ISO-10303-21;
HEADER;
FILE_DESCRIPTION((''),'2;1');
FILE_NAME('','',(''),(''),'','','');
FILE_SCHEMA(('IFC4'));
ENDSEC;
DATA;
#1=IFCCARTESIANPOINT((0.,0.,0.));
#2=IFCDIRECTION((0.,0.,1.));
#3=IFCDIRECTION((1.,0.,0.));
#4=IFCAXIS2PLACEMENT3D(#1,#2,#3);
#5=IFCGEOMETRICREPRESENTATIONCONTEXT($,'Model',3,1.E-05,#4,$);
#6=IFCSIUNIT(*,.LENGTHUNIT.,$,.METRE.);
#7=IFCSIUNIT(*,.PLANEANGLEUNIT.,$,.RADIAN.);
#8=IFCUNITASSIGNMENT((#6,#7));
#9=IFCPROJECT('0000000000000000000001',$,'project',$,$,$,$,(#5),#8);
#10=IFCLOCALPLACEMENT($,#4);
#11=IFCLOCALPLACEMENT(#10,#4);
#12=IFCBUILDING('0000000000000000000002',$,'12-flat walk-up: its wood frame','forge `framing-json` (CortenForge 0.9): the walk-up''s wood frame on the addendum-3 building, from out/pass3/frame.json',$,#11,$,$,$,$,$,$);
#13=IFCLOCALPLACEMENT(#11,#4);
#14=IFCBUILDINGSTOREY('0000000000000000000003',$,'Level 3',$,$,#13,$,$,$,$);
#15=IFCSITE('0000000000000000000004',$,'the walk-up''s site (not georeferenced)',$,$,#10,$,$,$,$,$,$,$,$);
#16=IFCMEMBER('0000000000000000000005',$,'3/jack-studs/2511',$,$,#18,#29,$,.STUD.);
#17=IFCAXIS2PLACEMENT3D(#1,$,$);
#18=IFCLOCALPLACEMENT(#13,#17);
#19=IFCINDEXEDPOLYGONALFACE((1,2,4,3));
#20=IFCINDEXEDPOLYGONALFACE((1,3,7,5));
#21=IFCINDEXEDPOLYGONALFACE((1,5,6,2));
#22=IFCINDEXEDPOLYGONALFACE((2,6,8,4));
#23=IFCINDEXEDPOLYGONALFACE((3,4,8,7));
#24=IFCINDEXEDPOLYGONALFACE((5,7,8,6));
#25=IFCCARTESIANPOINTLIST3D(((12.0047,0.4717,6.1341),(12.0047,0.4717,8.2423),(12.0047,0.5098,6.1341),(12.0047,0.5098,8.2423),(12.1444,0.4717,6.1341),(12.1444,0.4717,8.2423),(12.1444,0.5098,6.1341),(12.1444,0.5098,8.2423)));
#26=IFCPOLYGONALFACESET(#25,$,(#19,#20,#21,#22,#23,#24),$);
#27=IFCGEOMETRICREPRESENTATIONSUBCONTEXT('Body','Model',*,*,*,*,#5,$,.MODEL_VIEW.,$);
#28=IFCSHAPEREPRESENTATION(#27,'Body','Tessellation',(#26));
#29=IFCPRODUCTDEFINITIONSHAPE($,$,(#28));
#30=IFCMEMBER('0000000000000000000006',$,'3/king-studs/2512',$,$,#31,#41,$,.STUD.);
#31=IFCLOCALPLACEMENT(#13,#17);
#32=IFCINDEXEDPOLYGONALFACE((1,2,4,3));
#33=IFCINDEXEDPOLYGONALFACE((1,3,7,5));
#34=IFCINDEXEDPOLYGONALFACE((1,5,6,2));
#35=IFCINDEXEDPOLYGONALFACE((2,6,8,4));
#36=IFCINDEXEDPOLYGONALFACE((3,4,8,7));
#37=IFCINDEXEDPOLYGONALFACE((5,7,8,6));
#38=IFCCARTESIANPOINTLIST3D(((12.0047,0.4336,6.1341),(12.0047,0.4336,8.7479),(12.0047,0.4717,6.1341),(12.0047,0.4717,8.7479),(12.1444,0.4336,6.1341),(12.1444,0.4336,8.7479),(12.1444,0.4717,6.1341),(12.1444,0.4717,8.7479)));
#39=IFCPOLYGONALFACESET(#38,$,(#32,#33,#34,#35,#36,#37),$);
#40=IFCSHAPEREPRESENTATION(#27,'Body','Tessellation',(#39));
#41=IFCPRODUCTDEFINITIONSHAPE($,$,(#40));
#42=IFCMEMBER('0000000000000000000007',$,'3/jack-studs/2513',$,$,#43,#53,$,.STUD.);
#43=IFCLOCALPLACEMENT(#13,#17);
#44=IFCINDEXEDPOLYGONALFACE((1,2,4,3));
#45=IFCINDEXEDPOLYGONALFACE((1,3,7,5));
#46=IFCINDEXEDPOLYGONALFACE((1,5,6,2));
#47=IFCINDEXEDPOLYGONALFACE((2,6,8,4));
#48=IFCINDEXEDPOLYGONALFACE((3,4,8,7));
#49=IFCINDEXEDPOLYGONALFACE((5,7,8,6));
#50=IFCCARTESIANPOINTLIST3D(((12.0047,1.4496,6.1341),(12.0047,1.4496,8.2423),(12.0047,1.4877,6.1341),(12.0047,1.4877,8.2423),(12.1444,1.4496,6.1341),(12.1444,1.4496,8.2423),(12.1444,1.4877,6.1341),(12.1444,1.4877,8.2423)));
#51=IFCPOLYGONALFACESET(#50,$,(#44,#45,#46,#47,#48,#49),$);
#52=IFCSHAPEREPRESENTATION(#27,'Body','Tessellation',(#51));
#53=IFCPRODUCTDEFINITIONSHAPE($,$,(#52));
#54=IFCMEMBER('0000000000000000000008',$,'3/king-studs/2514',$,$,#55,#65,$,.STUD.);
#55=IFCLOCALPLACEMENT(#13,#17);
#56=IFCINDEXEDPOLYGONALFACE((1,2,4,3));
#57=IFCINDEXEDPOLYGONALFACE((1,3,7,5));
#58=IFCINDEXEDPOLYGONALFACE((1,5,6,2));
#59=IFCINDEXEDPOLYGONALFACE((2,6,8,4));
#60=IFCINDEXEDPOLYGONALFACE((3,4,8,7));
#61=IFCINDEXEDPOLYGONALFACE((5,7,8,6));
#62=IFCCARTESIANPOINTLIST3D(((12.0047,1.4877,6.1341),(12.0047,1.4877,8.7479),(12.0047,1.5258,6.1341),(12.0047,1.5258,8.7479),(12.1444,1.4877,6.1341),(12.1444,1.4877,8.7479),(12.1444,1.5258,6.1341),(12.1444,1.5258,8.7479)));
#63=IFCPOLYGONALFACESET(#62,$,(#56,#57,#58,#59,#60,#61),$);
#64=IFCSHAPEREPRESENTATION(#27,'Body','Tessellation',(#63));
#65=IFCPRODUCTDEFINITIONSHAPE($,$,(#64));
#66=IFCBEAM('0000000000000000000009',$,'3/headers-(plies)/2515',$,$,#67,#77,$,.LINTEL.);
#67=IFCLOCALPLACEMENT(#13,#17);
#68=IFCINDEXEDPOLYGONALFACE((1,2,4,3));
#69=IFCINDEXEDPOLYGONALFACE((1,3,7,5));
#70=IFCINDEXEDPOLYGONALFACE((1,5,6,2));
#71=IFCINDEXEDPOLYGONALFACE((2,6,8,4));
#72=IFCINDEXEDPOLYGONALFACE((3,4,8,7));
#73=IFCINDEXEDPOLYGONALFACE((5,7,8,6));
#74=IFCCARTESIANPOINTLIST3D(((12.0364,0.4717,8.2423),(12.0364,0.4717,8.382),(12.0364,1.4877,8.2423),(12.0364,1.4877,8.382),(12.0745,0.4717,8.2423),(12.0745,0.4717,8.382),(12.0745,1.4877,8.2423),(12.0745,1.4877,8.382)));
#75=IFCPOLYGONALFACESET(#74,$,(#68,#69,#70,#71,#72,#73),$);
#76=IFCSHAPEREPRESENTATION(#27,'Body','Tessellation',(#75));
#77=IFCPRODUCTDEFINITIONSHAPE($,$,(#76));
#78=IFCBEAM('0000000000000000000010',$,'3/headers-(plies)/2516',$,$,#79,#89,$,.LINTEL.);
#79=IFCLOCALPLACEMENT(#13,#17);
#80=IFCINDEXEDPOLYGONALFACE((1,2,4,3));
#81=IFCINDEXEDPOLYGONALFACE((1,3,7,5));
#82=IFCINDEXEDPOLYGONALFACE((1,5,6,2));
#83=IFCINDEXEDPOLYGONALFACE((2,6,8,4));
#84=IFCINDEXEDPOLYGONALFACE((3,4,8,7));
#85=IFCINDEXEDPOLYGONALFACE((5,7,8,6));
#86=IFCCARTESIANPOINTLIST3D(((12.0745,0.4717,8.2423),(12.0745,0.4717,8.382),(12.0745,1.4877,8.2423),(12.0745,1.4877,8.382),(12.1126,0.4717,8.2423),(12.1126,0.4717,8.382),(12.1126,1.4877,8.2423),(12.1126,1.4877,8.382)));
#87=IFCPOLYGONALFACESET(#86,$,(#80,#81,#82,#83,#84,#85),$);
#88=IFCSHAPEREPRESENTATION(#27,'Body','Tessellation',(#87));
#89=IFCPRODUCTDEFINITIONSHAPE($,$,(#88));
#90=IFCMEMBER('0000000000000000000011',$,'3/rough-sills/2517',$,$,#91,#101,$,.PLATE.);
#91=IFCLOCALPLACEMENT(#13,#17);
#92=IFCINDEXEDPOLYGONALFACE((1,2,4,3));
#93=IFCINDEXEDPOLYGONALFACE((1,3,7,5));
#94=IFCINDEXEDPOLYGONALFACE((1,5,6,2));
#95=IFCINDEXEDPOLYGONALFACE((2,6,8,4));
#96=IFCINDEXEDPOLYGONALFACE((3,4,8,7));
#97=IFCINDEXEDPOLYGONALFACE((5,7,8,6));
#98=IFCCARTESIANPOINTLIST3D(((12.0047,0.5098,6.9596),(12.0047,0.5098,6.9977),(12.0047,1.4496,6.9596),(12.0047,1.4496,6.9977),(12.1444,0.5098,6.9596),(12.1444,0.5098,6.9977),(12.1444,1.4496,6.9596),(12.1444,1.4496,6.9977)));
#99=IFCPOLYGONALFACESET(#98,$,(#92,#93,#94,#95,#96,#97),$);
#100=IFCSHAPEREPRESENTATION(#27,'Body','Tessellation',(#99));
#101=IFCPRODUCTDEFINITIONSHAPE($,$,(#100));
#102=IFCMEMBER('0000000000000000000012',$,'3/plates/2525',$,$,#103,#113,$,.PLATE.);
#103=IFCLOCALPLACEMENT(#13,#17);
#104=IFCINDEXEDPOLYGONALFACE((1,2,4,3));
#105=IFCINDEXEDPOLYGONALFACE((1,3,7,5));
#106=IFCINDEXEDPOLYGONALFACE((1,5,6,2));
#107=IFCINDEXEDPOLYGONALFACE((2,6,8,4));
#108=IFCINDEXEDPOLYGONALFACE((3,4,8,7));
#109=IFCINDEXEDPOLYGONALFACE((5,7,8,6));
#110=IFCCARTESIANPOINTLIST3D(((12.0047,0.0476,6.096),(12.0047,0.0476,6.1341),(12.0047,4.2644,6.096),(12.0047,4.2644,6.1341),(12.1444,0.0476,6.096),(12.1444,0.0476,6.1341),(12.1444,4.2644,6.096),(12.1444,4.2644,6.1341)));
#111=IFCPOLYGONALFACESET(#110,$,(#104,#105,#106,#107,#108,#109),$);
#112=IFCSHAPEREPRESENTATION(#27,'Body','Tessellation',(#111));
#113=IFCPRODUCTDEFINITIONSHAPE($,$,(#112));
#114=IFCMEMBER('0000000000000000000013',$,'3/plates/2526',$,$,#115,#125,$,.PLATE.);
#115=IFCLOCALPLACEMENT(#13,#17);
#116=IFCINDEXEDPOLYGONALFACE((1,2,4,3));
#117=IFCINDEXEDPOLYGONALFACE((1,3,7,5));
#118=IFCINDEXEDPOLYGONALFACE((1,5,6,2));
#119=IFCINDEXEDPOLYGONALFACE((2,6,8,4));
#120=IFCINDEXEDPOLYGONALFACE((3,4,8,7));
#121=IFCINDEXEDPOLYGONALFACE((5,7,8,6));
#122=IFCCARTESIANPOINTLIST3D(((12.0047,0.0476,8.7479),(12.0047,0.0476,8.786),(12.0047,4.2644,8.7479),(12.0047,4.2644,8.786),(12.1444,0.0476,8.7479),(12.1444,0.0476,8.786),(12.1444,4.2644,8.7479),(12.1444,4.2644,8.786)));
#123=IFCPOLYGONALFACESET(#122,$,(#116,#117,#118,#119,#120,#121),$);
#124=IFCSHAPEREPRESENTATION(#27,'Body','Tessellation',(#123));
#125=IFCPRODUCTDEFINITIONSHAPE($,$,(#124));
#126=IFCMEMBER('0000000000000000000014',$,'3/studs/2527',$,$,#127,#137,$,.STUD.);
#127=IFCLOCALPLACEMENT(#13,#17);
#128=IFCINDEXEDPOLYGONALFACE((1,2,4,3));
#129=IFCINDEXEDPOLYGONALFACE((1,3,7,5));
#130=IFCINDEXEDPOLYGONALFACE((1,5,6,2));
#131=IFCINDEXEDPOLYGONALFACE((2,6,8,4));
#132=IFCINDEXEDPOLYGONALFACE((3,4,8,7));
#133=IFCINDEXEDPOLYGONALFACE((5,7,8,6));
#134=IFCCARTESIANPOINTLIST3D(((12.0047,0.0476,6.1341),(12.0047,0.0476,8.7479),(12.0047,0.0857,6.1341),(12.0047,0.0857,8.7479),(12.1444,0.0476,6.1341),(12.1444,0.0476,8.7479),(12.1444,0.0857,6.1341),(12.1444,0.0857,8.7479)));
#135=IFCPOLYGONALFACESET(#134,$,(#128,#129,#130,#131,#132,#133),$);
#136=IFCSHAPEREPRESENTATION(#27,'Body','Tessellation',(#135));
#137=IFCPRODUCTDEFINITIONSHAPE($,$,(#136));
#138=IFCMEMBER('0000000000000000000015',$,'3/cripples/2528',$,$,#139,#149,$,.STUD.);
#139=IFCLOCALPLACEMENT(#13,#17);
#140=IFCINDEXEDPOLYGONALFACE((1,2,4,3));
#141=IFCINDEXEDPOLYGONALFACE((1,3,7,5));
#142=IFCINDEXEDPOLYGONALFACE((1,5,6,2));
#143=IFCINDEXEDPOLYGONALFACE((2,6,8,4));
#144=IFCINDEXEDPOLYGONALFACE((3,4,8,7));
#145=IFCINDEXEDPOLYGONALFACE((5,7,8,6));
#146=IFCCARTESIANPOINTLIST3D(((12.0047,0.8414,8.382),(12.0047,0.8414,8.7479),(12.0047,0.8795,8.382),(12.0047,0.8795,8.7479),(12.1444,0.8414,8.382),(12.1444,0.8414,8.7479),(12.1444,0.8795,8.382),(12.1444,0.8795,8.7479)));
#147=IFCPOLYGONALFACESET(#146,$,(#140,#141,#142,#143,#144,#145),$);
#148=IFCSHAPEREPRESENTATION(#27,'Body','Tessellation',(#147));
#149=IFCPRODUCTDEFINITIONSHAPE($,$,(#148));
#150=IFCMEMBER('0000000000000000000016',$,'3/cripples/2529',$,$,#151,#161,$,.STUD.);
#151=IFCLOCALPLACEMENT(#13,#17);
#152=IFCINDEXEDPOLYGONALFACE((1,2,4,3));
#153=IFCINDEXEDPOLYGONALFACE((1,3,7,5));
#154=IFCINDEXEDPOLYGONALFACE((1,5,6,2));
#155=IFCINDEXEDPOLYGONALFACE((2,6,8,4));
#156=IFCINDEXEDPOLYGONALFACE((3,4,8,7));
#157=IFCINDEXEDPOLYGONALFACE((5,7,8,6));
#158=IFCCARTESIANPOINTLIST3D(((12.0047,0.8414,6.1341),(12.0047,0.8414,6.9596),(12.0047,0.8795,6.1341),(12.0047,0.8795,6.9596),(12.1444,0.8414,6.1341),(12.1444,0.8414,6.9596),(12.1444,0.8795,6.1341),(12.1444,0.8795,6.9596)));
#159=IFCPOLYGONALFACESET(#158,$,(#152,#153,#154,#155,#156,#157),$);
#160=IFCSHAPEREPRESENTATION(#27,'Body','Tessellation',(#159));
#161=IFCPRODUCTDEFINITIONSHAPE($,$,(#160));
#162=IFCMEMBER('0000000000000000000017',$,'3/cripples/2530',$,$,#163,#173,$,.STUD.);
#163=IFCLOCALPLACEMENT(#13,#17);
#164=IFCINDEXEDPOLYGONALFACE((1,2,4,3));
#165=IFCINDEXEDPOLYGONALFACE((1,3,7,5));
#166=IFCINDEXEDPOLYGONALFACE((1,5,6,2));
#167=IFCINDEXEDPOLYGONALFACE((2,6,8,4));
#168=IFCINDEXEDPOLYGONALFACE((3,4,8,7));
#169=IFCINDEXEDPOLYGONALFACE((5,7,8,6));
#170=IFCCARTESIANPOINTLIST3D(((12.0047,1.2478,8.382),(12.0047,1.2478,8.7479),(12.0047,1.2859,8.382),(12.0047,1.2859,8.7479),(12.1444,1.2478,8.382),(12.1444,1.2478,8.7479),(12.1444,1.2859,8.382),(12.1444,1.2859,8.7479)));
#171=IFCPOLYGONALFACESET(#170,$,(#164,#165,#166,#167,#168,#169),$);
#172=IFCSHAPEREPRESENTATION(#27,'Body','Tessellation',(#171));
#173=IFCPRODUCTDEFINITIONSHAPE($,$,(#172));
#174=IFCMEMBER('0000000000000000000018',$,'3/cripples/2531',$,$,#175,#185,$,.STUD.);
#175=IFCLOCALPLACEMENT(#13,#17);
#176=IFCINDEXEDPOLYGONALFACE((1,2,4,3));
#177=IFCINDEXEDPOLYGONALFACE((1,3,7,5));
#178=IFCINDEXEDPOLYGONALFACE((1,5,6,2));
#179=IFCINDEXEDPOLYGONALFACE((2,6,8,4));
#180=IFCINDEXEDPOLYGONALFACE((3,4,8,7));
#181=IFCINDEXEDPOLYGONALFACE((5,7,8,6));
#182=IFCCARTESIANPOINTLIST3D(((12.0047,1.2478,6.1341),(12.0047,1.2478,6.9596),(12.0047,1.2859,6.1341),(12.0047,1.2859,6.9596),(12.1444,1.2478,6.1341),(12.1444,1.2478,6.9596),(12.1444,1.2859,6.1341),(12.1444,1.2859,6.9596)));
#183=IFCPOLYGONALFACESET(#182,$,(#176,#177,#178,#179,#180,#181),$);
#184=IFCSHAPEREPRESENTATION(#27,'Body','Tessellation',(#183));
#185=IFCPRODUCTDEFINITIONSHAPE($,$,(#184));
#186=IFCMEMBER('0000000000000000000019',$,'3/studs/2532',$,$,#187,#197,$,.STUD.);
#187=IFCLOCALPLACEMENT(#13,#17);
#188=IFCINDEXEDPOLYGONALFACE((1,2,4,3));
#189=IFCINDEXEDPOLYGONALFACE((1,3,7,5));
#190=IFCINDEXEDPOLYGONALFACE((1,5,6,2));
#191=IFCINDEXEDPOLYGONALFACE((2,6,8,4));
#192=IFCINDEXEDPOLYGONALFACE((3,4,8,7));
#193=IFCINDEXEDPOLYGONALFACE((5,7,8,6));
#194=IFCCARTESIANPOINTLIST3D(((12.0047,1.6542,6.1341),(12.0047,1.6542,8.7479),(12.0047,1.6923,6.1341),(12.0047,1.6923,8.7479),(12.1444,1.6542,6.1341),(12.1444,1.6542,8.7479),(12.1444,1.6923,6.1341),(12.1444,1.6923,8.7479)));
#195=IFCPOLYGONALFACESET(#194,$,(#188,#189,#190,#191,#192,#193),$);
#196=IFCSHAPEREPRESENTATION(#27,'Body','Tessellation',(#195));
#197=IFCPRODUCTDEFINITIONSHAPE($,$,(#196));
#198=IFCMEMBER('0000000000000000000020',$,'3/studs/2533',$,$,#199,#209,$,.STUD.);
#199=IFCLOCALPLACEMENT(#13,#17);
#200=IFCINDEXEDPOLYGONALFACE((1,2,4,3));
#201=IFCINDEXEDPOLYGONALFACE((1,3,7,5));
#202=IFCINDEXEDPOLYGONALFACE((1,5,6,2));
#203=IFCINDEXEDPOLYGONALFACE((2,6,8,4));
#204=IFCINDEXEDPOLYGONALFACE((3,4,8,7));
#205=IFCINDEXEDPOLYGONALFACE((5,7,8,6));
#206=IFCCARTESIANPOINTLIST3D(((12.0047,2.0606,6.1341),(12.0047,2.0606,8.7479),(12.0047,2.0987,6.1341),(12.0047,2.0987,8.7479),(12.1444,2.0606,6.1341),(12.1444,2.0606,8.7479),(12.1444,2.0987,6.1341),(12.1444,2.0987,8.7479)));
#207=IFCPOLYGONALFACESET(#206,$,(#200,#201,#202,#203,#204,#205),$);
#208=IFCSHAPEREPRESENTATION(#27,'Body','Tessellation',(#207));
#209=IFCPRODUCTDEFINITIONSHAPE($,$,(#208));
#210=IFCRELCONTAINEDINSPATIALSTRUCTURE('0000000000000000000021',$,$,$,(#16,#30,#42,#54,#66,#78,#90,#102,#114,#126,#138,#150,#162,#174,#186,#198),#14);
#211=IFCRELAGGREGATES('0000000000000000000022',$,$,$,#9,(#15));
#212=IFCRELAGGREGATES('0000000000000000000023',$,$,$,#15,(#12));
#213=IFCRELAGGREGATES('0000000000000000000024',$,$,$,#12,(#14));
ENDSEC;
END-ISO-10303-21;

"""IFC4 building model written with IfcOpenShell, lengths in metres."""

from ifc_helpers import new_model, si_unit, frame, frame_2d, origin, origin_with_axes, place, context, subcontext, project, spatial, rectangle, extrude, element, save


model = new_model("IFC4")

# Units and contexts
model_context = context("Model", 3, precision=1e-05, world=origin_with_axes())
body_context = subcontext(model_context, "Body", "Model", "MODEL_VIEW")
ifc_project = project(units=[si_unit("LENGTHUNIT", "METRE"), si_unit("PLANEANGLEUNIT", "RADIAN")], contexts=[model_context])

# Site, building, storey
site_placement = place(None, origin_with_axes())
site = spatial("IfcSite", under=ifc_project, at=site_placement, Name="the walk-up's site (not georeferenced)")
building_placement = place(site_placement, origin_with_axes())
building = spatial("IfcBuilding", under=site, at=building_placement, Name="12-flat walk-up: its wood frame", Description="forge `framing-json` (CortenForge 0.9): the walk-up's wood frame on the addendum-3 building, from out/pass3/frame.json")
storey_placement = place(building_placement, origin_with_axes())
storey = spatial("IfcBuildingStorey", under=building, at=storey_placement, Name="Level 3")

# Members
member_1_placement = place(storey_placement, frame((12.0047, 0.4717, 6.1341), z_axis=(0.0, 0.0, 1.0), x_axis=(1.0, 0.0, 0.0)))
element("IfcMember", 1, at=member_1_placement, inside=storey, Name="3/jack-studs/2511", PredefinedType="STUD", context=body_context, shape_type="SweptSolid", body=[
    extrude(rectangle(XDim=0.1397, YDim=0.0381, at=frame_2d((0.0698, 0.019))), origin(), (0.0, 0.0, 1.0), 2.1082),
])
member_2_placement = place(storey_placement, frame((12.0047, 0.4336, 6.1341), z_axis=(0.0, 0.0, 1.0), x_axis=(1.0, 0.0, 0.0)))
element("IfcMember", 2, at=member_2_placement, inside=storey, Name="3/king-studs/2512", PredefinedType="STUD", context=body_context, shape_type="SweptSolid", body=[
    extrude(rectangle(XDim=0.1397, YDim=0.0381, at=frame_2d((0.0698, 0.0191))), origin(), (0.0, 0.0, 1.0), 2.6138),
])
member_3_placement = place(storey_placement, frame((12.0047, 1.4496, 6.1341), z_axis=(0.0, 0.0, 1.0), x_axis=(1.0, 0.0, 0.0)))
element("IfcMember", 3, at=member_3_placement, inside=storey, Name="3/jack-studs/2513", PredefinedType="STUD", context=body_context, shape_type="SweptSolid", body=[
    extrude(rectangle(XDim=0.1397, YDim=0.0381, at=frame_2d((0.0698, 0.0191))), origin(), (0.0, 0.0, 1.0), 2.1082),
])
member_4_placement = place(storey_placement, frame((12.0047, 1.4877, 6.1341), z_axis=(0.0, 0.0, 1.0), x_axis=(1.0, 0.0, 0.0)))
element("IfcMember", 4, at=member_4_placement, inside=storey, Name="3/king-studs/2514", PredefinedType="STUD", context=body_context, shape_type="SweptSolid", body=[
    extrude(rectangle(XDim=0.1397, YDim=0.0381, at=frame_2d((0.0698, 0.0191))), origin(), (0.0, 0.0, 1.0), 2.6138),
])

# Beams
for number, where, z_axis, x_axis, name in (
    (5, (12.0364, 0.4717, 8.2423), (0.0, 0.0, 1.0), (1.0, 0.0, 0.0), "3/headers-(plies)/2515"),
    (6, (12.0745, 0.4717, 8.2423), (0.0, 0.0, 1.0), (1.0, 0.0, 0.0), "3/headers-(plies)/2516"),
):
    element("IfcBeam", number, at=place(storey_placement, frame(where, z_axis=z_axis, x_axis=x_axis)), inside=storey, Name=name, PredefinedType="LINTEL", context=body_context, shape_type="SweptSolid", body=[
        extrude(rectangle(XDim=0.0381, YDim=1.016, at=frame_2d((0.0191, 0.508))), origin(), (0.0, 0.0, 1.0), 0.1397),
    ])

# Members
member_5_placement = place(storey_placement, frame((12.0047, 0.5098, 6.9596), z_axis=(0.0, 0.0, 1.0), x_axis=(1.0, 0.0, 0.0)))
element("IfcMember", 7, at=member_5_placement, inside=storey, Name="3/rough-sills/2517", PredefinedType="PLATE", context=body_context, shape_type="SweptSolid", body=[
    extrude(rectangle(XDim=0.1397, YDim=0.9398, at=frame_2d((0.0698, 0.4699))), origin(), (0.0, 0.0, 1.0), 0.0381),
])
for number, where, z_axis, x_axis, name in (
    (8, (12.0047, 0.0476, 6.096), (0.0, 0.0, 1.0), (1.0, 0.0, 0.0), "3/plates/2525"),
    (9, (12.0047, 0.0476, 8.7479), (0.0, 0.0, 1.0), (1.0, 0.0, 0.0), "3/plates/2526"),
):
    element("IfcMember", number, at=place(storey_placement, frame(where, z_axis=z_axis, x_axis=x_axis)), inside=storey, Name=name, PredefinedType="PLATE", context=body_context, shape_type="SweptSolid", body=[
        extrude(rectangle(XDim=0.1397, YDim=4.2168, at=frame_2d((0.0698, 2.1084))), origin(), (0.0, 0.0, 1.0), 0.0381),
    ])
member_6_placement = place(storey_placement, frame((12.0047, 0.0476, 6.1341), z_axis=(0.0, 0.0, 1.0), x_axis=(1.0, 0.0, 0.0)))
element("IfcMember", 10, at=member_6_placement, inside=storey, Name="3/studs/2527", PredefinedType="STUD", context=body_context, shape_type="SweptSolid", body=[
    extrude(rectangle(XDim=0.1397, YDim=0.0381, at=frame_2d((0.0698, 0.019))), origin(), (0.0, 0.0, 1.0), 2.6138),
])
member_7_placement = place(storey_placement, frame((12.0047, 0.8414, 8.382), z_axis=(0.0, 0.0, 1.0), x_axis=(1.0, 0.0, 0.0)))
element("IfcMember", 11, at=member_7_placement, inside=storey, Name="3/cripples/2528", PredefinedType="STUD", context=body_context, shape_type="SweptSolid", body=[
    extrude(rectangle(XDim=0.1397, YDim=0.0381, at=frame_2d((0.0698, 0.0191))), origin(), (0.0, 0.0, 1.0), 0.3659),
])
member_8_placement = place(storey_placement, frame((12.0047, 0.8414, 6.1341), z_axis=(0.0, 0.0, 1.0), x_axis=(1.0, 0.0, 0.0)))
element("IfcMember", 12, at=member_8_placement, inside=storey, Name="3/cripples/2529", PredefinedType="STUD", context=body_context, shape_type="SweptSolid", body=[
    extrude(rectangle(XDim=0.1397, YDim=0.0381, at=frame_2d((0.0698, 0.0191))), origin(), (0.0, 0.0, 1.0), 0.8255),
])
member_9_placement = place(storey_placement, frame((12.0047, 1.2478, 8.382), z_axis=(0.0, 0.0, 1.0), x_axis=(1.0, 0.0, 0.0)))
element("IfcMember", 13, at=member_9_placement, inside=storey, Name="3/cripples/2530", PredefinedType="STUD", context=body_context, shape_type="SweptSolid", body=[
    extrude(rectangle(XDim=0.1397, YDim=0.0381, at=frame_2d((0.0698, 0.0191))), origin(), (0.0, 0.0, 1.0), 0.3659),
])
member_10_placement = place(storey_placement, frame((12.0047, 1.2478, 6.1341), z_axis=(0.0, 0.0, 1.0), x_axis=(1.0, 0.0, 0.0)))
element("IfcMember", 14, at=member_10_placement, inside=storey, Name="3/cripples/2531", PredefinedType="STUD", context=body_context, shape_type="SweptSolid", body=[
    extrude(rectangle(XDim=0.1397, YDim=0.0381, at=frame_2d((0.0698, 0.0191))), origin(), (0.0, 0.0, 1.0), 0.8255),
])
for number, where, z_axis, x_axis, name in (
    (15, (12.0047, 1.6542, 6.1341), (0.0, 0.0, 1.0), (1.0, 0.0, 0.0), "3/studs/2532"),
    (16, (12.0047, 2.0606, 6.1341), (0.0, 0.0, 1.0), (1.0, 0.0, 0.0), "3/studs/2533"),
):
    element("IfcMember", number, at=place(storey_placement, frame(where, z_axis=z_axis, x_axis=x_axis)), inside=storey, Name=name, PredefinedType="STUD", context=body_context, shape_type="SweptSolid", body=[
        extrude(rectangle(XDim=0.1397, YDim=0.0381, at=frame_2d((0.0698, 0.0191))), origin(), (0.0, 0.0, 1.0), 2.6138),
    ])

save(model, "model.ifc")
